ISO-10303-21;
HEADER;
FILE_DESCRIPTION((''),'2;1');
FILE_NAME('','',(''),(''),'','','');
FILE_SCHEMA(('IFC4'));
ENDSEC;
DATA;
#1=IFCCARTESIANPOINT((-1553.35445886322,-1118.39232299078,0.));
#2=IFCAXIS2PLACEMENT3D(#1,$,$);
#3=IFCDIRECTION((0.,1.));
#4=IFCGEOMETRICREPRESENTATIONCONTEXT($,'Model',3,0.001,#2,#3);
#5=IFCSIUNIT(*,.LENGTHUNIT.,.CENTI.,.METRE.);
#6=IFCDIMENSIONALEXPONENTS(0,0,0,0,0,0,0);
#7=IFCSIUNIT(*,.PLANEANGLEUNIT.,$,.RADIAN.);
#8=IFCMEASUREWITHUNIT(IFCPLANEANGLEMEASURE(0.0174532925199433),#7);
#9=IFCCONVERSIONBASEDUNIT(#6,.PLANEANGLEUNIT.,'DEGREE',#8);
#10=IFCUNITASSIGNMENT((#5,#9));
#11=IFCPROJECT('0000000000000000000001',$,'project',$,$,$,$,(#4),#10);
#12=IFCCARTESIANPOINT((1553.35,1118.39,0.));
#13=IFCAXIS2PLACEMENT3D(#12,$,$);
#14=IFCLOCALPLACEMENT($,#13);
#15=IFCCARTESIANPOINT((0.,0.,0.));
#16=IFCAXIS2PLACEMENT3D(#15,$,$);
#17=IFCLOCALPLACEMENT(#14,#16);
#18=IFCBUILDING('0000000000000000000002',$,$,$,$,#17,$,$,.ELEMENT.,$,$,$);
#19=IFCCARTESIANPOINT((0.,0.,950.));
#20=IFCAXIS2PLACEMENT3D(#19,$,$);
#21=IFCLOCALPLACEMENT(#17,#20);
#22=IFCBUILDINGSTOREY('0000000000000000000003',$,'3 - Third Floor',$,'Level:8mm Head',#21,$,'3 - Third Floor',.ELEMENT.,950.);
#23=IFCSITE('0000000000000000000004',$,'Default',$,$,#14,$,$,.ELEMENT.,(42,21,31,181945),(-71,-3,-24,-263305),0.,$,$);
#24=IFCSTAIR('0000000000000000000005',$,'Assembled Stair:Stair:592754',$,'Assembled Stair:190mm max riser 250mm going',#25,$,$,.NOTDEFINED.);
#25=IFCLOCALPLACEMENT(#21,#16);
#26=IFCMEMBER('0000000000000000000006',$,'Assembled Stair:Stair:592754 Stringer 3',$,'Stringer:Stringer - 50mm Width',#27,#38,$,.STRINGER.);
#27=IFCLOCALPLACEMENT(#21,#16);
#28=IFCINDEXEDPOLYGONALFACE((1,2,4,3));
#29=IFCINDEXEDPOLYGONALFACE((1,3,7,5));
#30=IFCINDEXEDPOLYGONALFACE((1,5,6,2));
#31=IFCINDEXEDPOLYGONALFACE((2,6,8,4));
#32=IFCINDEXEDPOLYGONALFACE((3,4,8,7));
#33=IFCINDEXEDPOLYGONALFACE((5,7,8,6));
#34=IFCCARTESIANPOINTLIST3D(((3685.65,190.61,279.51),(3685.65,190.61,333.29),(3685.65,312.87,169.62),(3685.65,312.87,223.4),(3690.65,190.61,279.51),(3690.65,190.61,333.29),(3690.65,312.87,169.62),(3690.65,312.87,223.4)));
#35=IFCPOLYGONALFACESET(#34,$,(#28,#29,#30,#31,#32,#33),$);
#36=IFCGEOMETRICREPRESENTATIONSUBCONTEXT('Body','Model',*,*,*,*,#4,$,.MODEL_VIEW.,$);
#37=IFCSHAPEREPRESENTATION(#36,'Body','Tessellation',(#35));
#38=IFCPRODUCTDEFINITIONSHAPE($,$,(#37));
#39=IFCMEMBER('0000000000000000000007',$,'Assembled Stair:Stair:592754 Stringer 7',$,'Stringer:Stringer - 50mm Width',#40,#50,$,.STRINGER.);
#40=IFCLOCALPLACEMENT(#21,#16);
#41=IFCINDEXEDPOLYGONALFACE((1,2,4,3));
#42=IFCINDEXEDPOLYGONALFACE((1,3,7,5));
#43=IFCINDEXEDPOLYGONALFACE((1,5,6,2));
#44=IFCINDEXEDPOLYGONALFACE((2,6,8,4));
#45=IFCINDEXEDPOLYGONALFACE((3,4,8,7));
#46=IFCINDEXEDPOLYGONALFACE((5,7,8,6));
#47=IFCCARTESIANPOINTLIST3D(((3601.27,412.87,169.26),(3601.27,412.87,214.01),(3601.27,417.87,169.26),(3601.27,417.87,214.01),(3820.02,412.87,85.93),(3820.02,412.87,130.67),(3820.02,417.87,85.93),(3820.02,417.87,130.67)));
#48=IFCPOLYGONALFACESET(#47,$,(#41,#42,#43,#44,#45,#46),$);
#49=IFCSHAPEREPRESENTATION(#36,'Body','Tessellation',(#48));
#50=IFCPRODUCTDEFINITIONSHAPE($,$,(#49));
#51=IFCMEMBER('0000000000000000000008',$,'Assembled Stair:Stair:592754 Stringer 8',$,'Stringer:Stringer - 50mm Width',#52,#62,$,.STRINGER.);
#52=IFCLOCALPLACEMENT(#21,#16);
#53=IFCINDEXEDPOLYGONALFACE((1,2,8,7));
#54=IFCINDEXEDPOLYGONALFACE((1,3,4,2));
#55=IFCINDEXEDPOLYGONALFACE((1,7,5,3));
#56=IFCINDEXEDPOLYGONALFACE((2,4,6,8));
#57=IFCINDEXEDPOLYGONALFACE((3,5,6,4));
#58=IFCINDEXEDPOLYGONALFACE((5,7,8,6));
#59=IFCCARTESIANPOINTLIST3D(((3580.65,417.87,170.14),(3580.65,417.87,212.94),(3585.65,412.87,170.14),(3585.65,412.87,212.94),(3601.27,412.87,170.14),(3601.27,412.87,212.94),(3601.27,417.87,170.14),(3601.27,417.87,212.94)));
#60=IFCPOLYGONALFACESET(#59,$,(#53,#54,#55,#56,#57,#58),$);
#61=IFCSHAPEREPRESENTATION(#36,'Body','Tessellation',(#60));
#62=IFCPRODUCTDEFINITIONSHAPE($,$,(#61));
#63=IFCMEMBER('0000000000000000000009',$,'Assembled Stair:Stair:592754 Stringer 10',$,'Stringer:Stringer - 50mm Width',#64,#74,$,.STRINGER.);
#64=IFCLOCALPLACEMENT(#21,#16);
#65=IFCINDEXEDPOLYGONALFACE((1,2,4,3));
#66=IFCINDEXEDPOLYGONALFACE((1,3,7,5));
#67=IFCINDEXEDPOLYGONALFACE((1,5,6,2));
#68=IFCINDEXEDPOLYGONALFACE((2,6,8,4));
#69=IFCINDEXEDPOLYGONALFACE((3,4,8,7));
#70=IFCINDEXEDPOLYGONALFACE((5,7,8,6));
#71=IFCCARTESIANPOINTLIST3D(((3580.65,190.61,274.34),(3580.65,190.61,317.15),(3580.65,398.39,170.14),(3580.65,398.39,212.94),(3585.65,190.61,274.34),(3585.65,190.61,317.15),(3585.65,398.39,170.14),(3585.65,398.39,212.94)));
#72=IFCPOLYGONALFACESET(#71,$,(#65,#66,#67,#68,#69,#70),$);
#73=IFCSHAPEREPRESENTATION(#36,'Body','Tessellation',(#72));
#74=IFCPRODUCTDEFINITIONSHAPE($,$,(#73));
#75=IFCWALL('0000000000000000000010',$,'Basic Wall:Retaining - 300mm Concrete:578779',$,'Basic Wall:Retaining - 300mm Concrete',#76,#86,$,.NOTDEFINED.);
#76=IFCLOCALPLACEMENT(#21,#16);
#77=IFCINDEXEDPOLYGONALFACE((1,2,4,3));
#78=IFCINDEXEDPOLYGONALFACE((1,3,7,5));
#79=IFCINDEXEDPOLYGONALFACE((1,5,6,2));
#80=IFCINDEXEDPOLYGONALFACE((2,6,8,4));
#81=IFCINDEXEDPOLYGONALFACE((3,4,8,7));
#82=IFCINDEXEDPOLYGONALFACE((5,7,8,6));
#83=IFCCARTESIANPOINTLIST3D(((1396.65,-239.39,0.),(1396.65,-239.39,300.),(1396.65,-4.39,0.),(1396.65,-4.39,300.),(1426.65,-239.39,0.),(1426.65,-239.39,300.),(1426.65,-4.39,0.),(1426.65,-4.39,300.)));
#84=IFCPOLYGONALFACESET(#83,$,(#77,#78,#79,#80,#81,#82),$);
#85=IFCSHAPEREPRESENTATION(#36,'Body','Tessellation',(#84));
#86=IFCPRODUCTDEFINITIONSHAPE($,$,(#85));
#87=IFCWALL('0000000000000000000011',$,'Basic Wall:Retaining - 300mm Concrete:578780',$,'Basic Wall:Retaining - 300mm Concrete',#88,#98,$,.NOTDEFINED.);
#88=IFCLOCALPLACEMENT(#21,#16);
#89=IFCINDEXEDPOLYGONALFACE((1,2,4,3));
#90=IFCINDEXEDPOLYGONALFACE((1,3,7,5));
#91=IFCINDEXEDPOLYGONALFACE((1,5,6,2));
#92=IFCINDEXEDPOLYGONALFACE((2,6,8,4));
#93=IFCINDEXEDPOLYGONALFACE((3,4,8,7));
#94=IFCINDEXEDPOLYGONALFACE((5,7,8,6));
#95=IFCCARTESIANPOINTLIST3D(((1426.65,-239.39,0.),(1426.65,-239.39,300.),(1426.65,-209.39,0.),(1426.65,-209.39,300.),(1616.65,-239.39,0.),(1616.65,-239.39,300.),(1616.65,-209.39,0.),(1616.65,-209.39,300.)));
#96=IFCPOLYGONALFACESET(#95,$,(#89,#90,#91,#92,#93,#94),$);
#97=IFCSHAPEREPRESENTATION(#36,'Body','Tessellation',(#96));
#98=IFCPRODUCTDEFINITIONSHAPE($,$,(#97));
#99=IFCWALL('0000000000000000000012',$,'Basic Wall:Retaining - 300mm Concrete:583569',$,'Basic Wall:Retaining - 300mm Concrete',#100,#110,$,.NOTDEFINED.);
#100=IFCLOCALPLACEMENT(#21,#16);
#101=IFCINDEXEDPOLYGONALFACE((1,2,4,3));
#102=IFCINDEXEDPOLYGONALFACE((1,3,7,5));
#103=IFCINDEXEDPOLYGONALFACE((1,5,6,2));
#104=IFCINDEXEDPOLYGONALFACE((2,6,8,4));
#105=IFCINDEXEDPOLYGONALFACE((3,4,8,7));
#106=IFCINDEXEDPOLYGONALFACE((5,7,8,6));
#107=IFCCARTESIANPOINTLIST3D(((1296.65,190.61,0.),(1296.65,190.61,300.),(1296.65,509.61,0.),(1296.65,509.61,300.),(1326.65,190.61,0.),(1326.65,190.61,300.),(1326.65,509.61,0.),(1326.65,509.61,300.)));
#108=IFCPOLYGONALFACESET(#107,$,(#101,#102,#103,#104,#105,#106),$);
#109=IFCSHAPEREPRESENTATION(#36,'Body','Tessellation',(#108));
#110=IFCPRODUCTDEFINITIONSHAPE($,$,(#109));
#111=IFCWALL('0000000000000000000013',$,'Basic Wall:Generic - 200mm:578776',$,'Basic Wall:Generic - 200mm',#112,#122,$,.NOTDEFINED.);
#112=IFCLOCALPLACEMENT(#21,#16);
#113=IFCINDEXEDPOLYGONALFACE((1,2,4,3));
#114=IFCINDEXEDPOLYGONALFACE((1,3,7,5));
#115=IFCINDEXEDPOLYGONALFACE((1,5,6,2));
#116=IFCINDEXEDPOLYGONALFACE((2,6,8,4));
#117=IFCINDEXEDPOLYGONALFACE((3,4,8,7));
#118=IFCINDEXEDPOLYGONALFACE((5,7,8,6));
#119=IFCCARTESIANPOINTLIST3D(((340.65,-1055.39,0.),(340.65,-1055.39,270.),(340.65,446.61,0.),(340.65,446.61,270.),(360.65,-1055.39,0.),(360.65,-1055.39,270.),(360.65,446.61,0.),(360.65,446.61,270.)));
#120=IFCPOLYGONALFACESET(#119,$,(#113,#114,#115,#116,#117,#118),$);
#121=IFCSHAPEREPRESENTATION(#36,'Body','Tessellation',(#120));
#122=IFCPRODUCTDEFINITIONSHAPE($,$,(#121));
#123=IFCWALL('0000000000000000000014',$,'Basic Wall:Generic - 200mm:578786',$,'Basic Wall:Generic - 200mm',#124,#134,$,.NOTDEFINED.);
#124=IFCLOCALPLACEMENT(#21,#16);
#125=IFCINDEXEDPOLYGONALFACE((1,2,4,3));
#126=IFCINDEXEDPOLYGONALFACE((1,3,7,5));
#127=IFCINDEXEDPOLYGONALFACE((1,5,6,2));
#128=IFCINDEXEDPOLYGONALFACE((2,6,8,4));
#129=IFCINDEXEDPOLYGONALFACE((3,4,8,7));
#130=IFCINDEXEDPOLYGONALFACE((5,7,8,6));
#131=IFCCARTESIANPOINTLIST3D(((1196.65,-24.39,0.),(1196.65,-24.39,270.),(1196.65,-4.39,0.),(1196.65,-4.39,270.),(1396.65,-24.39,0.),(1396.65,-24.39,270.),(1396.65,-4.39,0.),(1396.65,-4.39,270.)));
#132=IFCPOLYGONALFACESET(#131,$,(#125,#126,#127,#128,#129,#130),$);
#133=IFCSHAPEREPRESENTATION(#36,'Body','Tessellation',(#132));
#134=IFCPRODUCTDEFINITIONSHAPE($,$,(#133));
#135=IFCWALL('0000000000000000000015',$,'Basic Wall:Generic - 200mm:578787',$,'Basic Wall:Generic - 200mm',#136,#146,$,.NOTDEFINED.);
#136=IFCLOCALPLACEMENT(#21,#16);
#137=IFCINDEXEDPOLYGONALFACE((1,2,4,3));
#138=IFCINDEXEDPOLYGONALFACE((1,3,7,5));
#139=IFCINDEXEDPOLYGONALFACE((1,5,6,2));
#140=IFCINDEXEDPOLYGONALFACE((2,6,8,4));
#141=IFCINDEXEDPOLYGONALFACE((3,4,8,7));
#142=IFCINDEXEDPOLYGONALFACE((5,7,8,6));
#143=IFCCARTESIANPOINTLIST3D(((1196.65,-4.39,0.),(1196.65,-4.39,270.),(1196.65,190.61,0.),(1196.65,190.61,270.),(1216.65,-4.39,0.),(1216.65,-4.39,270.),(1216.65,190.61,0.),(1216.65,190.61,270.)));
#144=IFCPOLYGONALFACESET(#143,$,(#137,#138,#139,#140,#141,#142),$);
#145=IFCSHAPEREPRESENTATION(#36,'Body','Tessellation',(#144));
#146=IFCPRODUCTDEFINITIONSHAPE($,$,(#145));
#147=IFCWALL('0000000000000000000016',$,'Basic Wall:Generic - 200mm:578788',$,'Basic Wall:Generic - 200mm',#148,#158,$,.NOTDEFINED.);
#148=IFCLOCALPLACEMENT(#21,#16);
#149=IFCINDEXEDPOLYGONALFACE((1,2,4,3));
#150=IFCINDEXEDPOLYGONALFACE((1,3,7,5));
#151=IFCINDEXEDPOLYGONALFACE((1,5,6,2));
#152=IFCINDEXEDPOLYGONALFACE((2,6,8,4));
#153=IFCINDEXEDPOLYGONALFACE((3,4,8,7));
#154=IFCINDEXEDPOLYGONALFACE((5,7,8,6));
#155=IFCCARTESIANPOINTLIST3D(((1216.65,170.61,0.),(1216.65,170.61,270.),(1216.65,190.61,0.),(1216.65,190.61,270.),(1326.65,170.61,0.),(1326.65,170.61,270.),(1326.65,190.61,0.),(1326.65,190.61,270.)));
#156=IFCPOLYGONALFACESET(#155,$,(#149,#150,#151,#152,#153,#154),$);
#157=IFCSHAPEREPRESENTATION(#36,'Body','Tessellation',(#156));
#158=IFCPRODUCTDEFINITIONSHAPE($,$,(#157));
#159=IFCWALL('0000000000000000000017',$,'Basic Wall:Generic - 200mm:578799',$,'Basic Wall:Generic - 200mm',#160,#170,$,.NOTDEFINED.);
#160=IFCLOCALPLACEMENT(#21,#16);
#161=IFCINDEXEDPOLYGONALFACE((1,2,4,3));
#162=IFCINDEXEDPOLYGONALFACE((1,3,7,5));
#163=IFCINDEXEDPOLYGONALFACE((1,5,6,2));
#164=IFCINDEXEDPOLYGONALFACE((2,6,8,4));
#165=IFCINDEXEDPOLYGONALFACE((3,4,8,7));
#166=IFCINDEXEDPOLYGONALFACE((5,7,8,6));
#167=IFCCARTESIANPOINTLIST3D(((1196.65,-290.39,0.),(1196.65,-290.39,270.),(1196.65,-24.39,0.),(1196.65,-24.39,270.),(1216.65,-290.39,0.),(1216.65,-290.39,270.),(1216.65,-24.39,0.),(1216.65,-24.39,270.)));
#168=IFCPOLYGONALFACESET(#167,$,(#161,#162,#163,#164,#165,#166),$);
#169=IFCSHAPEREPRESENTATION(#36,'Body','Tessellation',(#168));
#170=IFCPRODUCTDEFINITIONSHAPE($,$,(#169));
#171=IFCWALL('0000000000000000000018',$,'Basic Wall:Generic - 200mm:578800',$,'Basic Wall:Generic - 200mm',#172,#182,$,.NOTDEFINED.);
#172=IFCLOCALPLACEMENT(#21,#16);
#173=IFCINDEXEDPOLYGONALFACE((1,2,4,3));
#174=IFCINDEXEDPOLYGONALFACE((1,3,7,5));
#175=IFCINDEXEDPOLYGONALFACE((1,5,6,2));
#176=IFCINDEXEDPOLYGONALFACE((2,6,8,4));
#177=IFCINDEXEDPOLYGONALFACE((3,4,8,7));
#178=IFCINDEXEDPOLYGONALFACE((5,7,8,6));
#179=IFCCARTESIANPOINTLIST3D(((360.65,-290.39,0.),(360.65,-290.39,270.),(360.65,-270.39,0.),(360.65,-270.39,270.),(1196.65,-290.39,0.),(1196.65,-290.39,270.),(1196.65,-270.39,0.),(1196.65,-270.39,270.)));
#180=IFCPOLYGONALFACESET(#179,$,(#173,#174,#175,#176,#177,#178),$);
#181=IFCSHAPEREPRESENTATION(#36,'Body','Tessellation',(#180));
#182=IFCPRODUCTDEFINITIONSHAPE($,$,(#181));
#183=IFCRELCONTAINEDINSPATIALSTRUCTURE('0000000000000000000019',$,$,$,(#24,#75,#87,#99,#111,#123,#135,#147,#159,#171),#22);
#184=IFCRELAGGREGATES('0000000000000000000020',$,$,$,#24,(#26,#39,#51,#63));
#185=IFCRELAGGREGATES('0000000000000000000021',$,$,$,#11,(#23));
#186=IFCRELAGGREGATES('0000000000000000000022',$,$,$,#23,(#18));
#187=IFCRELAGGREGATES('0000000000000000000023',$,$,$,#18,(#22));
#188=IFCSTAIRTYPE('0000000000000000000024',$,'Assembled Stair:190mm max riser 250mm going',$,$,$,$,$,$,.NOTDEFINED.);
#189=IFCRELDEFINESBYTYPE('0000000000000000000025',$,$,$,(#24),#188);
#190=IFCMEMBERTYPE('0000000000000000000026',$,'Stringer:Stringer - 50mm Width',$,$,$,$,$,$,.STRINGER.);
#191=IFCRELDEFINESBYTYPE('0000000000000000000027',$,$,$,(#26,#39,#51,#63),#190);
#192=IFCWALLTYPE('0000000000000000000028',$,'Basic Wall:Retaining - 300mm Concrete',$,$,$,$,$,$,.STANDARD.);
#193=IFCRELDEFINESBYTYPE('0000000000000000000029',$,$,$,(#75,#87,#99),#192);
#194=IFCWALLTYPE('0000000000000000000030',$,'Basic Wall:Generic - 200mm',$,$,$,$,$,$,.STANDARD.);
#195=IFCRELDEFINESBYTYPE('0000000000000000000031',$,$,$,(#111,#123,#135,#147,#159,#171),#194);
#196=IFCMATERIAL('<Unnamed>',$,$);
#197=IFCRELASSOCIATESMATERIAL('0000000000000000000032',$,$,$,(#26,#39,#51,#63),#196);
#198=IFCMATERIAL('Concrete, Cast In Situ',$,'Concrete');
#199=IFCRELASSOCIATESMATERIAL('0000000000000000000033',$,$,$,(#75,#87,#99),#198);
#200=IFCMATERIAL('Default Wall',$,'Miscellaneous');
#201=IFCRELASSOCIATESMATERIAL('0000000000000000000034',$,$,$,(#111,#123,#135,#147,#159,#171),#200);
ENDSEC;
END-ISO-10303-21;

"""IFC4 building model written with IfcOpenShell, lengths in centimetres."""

from ifc_helpers import new_model, entity, si_unit, converted_unit, direction, frame, origin, place, context, subcontext, project, spatial, indexed_curve, outline, extrude, material, type_object, element, aggregate, save


model = new_model("IFC4")

# Units and contexts
model_context = context("Model", 3, precision=0.001, world=frame((-1553.35445886322, -1118.39232299078, 0.0)), true_north=direction((0.0, 1.0)))
body_context = subcontext(model_context, "Body", "Model", "MODEL_VIEW")
ifc_project = project(units=[si_unit("LENGTHUNIT", "METRE", prefix="CENTI"), converted_unit("PLANEANGLEUNIT", "DEGREE", entity("IfcPlaneAngleMeasure", 0.0174532925199433), si_unit("PLANEANGLEUNIT", "RADIAN"), dimensions=[0, 0, 0, 0, 0, 0, 0])], contexts=[model_context])

# Site, building, storey
site_placement = place(None, frame((1553.35, 1118.39, 0.0)))
site = spatial("IfcSite", under=ifc_project, at=site_placement, Name="Default", CompositionType="ELEMENT", RefLatitude=(42, 21, 31, 181945), RefLongitude=(-71, -3, -24, -263305), RefElevation=0.0)
building_placement = place(site_placement, origin())
building = spatial("IfcBuilding", under=site, at=building_placement, CompositionType="ELEMENT")
storey_placement = place(building_placement, frame((0.0, 0.0, 950.0)))
storey = spatial("IfcBuildingStorey", under=building, at=storey_placement, Name="3 - Third Floor", ObjectType="Level:8mm Head", LongName="3 - Third Floor", CompositionType="ELEMENT", Elevation=950.0)

# Stair, members
stair_type = type_object("IfcStairType", Name="Assembled Stair:190mm max riser 250mm going", PredefinedType="NOTDEFINED")
stair_placement = place(storey_placement, origin())
stair = element("IfcStair", 1, at=stair_placement, inside=storey, type_object=stair_type, Name="Assembled Stair:Stair:592754", ObjectType="Assembled Stair:190mm max riser 250mm going", PredefinedType="NOTDEFINED")
ifc_material_1 = material(Name="<Unnamed>")
member_type = type_object("IfcMemberType", Name="Stringer:Stringer - 50mm Width", PredefinedType="STRINGER")
member_1_placement = place(stair_placement, origin())
member_1 = element("IfcMember", 2, at=member_1_placement, type_object=member_type, material=ifc_material_1, Name="Assembled Stair:Stair:592754 Stringer 3", ObjectType="Stringer:Stringer - 50mm Width", PredefinedType="STRINGER", context=body_context, shape_type="SweptSolid", body=[
    extrude(outline(indexed_curve([(-64.22, -20.0), (100.17, -20.0), (64.22, 20.0), (-100.17, 20.0), (-64.22, -20.0)], self_intersect=False)), frame((3685.65, 251.74, 251.46), z_axis=(1.0, 0.0, 0.0), x_axis=(0.0, -0.74373, 0.668481)), (0.0, 0.0, 1.0), 5.0),
])
member_2_placement = place(stair_placement, origin())
member_2 = element("IfcMember", 3, at=member_2_placement, type_object=member_type, material=ifc_material_1, Name="Assembled Stair:Stair:592754 Stringer 7", ObjectType="Stringer:Stringer - 50mm Width", PredefinedType="STRINGER", context=body_context, shape_type="SweptSolid", body=[
    extrude(outline(indexed_curve([(-125.01, -20.91), (109.08, -20.91), (125.01, 20.91), (-109.08, 20.91), (-125.01, -20.91)], self_intersect=False)), frame((3710.65, 412.87, 149.97), z_axis=(0.0, 1.0, 0.0), x_axis=(-0.934489, 0.0, 0.355992)), (0.0, 0.0, 1.0), 5.0),
])
member_3_placement = place(stair_placement, origin())
member_3 = element("IfcMember", 4, at=member_3_placement, type_object=member_type, material=ifc_material_1, Name="Assembled Stair:Stair:592754 Stringer 8", ObjectType="Stringer:Stringer - 50mm Width", PredefinedType="STRINGER", context=body_context, shape_type="SweptSolid", body=[
    extrude(outline(indexed_curve([(-9.06, -2.5), (11.56, -2.5), (6.56, 2.5), (-9.06, 2.5), (-9.06, -2.5)], self_intersect=False)), frame((3592.21, 415.37, 170.14), z_axis=(0.0, 0.0, 1.0), x_axis=(-1.0, 0.0, 0.0)), (0.0, 0.0, 1.0), 42.8),
])
member_4_placement = place(stair_placement, origin())
member_4 = element("IfcMember", 5, at=member_4_placement, type_object=member_type, material=ifc_material_1, Name="Assembled Stair:Stair:592754 Stringer 10", ObjectType="Stringer:Stringer - 50mm Width", PredefinedType="STRINGER", context=body_context, shape_type="SweptSolid", body=[
    extrude(outline(indexed_curve([(-106.63, -19.13), (125.82, -19.13), (106.63, 19.13), (-125.82, 19.13), (-106.63, -19.13)], self_intersect=False)), frame((3580.65, 294.5, 243.64), z_axis=(1.0, 0.0, 0.0), x_axis=(0.0, -0.893886, 0.448294)), (0.0, 0.0, 1.0), 5.0),
])
aggregate(stair, [member_1, member_2, member_3, member_4])

# Walls
ifc_material_2 = material(Name="Concrete, Cast In Situ", Category="Concrete")
wall_type_1 = type_object("IfcWallType", Name="Basic Wall:Retaining - 300mm Concrete", PredefinedType="STANDARD")
wall_1_placement = place(storey_placement, frame((1411.65, -4.39, 0.0), z_axis=(0.0, 0.0, 1.0), x_axis=(0.0, -1.0, 0.0)))
element("IfcWall", 6, at=wall_1_placement, inside=storey, type_object=wall_type_1, material=ifc_material_2, Name="Basic Wall:Retaining - 300mm Concrete:578779", ObjectType="Basic Wall:Retaining - 300mm Concrete", PredefinedType="NOTDEFINED", context=body_context, shape_type="SweptSolid", body=[
    extrude(outline(indexed_curve([(235.0, 15.0), (0.0, 15.0), (0.0, -15.0), (235.0, -15.0), (235.0, 15.0)], self_intersect=False)), origin(), (0.0, 0.0, 1.0), 300.0),
])
wall_2_placement = place(storey_placement, frame((1426.65, -224.39, 0.0)))
element("IfcWall", 7, at=wall_2_placement, inside=storey, type_object=wall_type_1, material=ifc_material_2, Name="Basic Wall:Retaining - 300mm Concrete:578780", ObjectType="Basic Wall:Retaining - 300mm Concrete", PredefinedType="NOTDEFINED", context=body_context, shape_type="SweptSolid", body=[
    extrude(outline(indexed_curve([(190.0, 15.0), (0.0, 15.0), (0.0, -15.0), (190.0, -15.0), (190.0, 15.0)], self_intersect=False)), origin(), (0.0, 0.0, 1.0), 300.0),
])
wall_3_placement = place(storey_placement, frame((1311.65, 509.61, 0.0), z_axis=(0.0, 0.0, 1.0), x_axis=(0.0, -1.0, 0.0)))
element("IfcWall", 8, at=wall_3_placement, inside=storey, type_object=wall_type_1, material=ifc_material_2, Name="Basic Wall:Retaining - 300mm Concrete:583569", ObjectType="Basic Wall:Retaining - 300mm Concrete", PredefinedType="NOTDEFINED", context=body_context, shape_type="SweptSolid", body=[
    extrude(outline(indexed_curve([(319.0, 15.0), (0.0, 15.0), (0.0, -15.0), (319.0, -15.0), (319.0, 15.0)], self_intersect=False)), origin(), (0.0, 0.0, 1.0), 300.0),
])
ifc_material_3 = material(Name="Default Wall", Category="Miscellaneous")
wall_type_2 = type_object("IfcWallType", Name="Basic Wall:Generic - 200mm", PredefinedType="STANDARD")
wall_4_placement = place(storey_placement, frame((350.65, 446.61, 0.0), z_axis=(0.0, 0.0, 1.0), x_axis=(0.0, -1.0, 0.0)))
element("IfcWall", 9, at=wall_4_placement, inside=storey, type_object=wall_type_2, material=ifc_material_3, Name="Basic Wall:Generic - 200mm:578776", ObjectType="Basic Wall:Generic - 200mm", PredefinedType="NOTDEFINED", context=body_context, shape_type="SweptSolid", body=[
    extrude(outline(indexed_curve([(1502.0, 10.0), (0.0, 10.0), (0.0, -10.0), (1502.0, -10.0), (1502.0, 10.0)], self_intersect=False)), origin(), (0.0, 0.0, 1.0), 270.0),
])
wall_5_placement = place(storey_placement, frame((1396.65, -14.39, 0.0), z_axis=(0.0, 0.0, 1.0), x_axis=(-1.0, 0.0, 0.0)))
element("IfcWall", 10, at=wall_5_placement, inside=storey, type_object=wall_type_2, material=ifc_material_3, Name="Basic Wall:Generic - 200mm:578786", ObjectType="Basic Wall:Generic - 200mm", PredefinedType="NOTDEFINED", context=body_context, shape_type="SweptSolid", body=[
    extrude(outline(indexed_curve([(200.0, 10.0), (0.0, 10.0), (0.0, -10.0), (200.0, -10.0), (200.0, 10.0)], self_intersect=False)), origin(), (0.0, 0.0, 1.0), 270.0),
])
wall_6_placement = place(storey_placement, frame((1206.65, -4.39, 0.0), z_axis=(0.0, 0.0, 1.0), x_axis=(0.0, 1.0, 0.0)))
element("IfcWall", 11, at=wall_6_placement, inside=storey, type_object=wall_type_2, material=ifc_material_3, Name="Basic Wall:Generic - 200mm:578787", ObjectType="Basic Wall:Generic - 200mm", PredefinedType="NOTDEFINED", context=body_context, shape_type="SweptSolid", body=[
    extrude(outline(indexed_curve([(195.0, 10.0), (0.0, 10.0), (0.0, -10.0), (195.0, -10.0), (195.0, 10.0)], self_intersect=False)), origin(), (0.0, 0.0, 1.0), 270.0),
])
wall_7_placement = place(storey_placement, frame((1216.65, 180.61, 0.0)))
element("IfcWall", 12, at=wall_7_placement, inside=storey, type_object=wall_type_2, material=ifc_material_3, Name="Basic Wall:Generic - 200mm:578788", ObjectType="Basic Wall:Generic - 200mm", PredefinedType="NOTDEFINED", context=body_context, shape_type="SweptSolid", body=[
    extrude(outline(indexed_curve([(110.0, 10.0), (0.0, 10.0), (0.0, -10.0), (110.0, -10.0), (110.0, 10.0)], self_intersect=False)), origin(), (0.0, 0.0, 1.0), 270.0),
])
wall_8_placement = place(storey_placement, frame((1206.65, -24.39, 0.0), z_axis=(0.0, 0.0, 1.0), x_axis=(0.0, -1.0, 0.0)))
element("IfcWall", 13, at=wall_8_placement, inside=storey, type_object=wall_type_2, material=ifc_material_3, Name="Basic Wall:Generic - 200mm:578799", ObjectType="Basic Wall:Generic - 200mm", PredefinedType="NOTDEFINED", context=body_context, shape_type="SweptSolid", body=[
    extrude(outline(indexed_curve([(266.0, 10.0), (0.0, 10.0), (0.0, -10.0), (266.0, -10.0), (266.0, 10.0)], self_intersect=False)), origin(), (0.0, 0.0, 1.0), 270.0),
])
wall_9_placement = place(storey_placement, frame((1196.65, -280.39, 0.0), z_axis=(0.0, 0.0, 1.0), x_axis=(-1.0, 0.0, 0.0)))
element("IfcWall", 14, at=wall_9_placement, inside=storey, type_object=wall_type_2, material=ifc_material_3, Name="Basic Wall:Generic - 200mm:578800", ObjectType="Basic Wall:Generic - 200mm", PredefinedType="NOTDEFINED", context=body_context, shape_type="SweptSolid", body=[
    extrude(outline(indexed_curve([(836.0, 10.0), (0.0, 10.0), (0.0, -10.0), (836.0, -10.0), (836.0, 10.0)], self_intersect=False)), origin(), (0.0, 0.0, 1.0), 270.0),
])

save(model, "model.ifc")
